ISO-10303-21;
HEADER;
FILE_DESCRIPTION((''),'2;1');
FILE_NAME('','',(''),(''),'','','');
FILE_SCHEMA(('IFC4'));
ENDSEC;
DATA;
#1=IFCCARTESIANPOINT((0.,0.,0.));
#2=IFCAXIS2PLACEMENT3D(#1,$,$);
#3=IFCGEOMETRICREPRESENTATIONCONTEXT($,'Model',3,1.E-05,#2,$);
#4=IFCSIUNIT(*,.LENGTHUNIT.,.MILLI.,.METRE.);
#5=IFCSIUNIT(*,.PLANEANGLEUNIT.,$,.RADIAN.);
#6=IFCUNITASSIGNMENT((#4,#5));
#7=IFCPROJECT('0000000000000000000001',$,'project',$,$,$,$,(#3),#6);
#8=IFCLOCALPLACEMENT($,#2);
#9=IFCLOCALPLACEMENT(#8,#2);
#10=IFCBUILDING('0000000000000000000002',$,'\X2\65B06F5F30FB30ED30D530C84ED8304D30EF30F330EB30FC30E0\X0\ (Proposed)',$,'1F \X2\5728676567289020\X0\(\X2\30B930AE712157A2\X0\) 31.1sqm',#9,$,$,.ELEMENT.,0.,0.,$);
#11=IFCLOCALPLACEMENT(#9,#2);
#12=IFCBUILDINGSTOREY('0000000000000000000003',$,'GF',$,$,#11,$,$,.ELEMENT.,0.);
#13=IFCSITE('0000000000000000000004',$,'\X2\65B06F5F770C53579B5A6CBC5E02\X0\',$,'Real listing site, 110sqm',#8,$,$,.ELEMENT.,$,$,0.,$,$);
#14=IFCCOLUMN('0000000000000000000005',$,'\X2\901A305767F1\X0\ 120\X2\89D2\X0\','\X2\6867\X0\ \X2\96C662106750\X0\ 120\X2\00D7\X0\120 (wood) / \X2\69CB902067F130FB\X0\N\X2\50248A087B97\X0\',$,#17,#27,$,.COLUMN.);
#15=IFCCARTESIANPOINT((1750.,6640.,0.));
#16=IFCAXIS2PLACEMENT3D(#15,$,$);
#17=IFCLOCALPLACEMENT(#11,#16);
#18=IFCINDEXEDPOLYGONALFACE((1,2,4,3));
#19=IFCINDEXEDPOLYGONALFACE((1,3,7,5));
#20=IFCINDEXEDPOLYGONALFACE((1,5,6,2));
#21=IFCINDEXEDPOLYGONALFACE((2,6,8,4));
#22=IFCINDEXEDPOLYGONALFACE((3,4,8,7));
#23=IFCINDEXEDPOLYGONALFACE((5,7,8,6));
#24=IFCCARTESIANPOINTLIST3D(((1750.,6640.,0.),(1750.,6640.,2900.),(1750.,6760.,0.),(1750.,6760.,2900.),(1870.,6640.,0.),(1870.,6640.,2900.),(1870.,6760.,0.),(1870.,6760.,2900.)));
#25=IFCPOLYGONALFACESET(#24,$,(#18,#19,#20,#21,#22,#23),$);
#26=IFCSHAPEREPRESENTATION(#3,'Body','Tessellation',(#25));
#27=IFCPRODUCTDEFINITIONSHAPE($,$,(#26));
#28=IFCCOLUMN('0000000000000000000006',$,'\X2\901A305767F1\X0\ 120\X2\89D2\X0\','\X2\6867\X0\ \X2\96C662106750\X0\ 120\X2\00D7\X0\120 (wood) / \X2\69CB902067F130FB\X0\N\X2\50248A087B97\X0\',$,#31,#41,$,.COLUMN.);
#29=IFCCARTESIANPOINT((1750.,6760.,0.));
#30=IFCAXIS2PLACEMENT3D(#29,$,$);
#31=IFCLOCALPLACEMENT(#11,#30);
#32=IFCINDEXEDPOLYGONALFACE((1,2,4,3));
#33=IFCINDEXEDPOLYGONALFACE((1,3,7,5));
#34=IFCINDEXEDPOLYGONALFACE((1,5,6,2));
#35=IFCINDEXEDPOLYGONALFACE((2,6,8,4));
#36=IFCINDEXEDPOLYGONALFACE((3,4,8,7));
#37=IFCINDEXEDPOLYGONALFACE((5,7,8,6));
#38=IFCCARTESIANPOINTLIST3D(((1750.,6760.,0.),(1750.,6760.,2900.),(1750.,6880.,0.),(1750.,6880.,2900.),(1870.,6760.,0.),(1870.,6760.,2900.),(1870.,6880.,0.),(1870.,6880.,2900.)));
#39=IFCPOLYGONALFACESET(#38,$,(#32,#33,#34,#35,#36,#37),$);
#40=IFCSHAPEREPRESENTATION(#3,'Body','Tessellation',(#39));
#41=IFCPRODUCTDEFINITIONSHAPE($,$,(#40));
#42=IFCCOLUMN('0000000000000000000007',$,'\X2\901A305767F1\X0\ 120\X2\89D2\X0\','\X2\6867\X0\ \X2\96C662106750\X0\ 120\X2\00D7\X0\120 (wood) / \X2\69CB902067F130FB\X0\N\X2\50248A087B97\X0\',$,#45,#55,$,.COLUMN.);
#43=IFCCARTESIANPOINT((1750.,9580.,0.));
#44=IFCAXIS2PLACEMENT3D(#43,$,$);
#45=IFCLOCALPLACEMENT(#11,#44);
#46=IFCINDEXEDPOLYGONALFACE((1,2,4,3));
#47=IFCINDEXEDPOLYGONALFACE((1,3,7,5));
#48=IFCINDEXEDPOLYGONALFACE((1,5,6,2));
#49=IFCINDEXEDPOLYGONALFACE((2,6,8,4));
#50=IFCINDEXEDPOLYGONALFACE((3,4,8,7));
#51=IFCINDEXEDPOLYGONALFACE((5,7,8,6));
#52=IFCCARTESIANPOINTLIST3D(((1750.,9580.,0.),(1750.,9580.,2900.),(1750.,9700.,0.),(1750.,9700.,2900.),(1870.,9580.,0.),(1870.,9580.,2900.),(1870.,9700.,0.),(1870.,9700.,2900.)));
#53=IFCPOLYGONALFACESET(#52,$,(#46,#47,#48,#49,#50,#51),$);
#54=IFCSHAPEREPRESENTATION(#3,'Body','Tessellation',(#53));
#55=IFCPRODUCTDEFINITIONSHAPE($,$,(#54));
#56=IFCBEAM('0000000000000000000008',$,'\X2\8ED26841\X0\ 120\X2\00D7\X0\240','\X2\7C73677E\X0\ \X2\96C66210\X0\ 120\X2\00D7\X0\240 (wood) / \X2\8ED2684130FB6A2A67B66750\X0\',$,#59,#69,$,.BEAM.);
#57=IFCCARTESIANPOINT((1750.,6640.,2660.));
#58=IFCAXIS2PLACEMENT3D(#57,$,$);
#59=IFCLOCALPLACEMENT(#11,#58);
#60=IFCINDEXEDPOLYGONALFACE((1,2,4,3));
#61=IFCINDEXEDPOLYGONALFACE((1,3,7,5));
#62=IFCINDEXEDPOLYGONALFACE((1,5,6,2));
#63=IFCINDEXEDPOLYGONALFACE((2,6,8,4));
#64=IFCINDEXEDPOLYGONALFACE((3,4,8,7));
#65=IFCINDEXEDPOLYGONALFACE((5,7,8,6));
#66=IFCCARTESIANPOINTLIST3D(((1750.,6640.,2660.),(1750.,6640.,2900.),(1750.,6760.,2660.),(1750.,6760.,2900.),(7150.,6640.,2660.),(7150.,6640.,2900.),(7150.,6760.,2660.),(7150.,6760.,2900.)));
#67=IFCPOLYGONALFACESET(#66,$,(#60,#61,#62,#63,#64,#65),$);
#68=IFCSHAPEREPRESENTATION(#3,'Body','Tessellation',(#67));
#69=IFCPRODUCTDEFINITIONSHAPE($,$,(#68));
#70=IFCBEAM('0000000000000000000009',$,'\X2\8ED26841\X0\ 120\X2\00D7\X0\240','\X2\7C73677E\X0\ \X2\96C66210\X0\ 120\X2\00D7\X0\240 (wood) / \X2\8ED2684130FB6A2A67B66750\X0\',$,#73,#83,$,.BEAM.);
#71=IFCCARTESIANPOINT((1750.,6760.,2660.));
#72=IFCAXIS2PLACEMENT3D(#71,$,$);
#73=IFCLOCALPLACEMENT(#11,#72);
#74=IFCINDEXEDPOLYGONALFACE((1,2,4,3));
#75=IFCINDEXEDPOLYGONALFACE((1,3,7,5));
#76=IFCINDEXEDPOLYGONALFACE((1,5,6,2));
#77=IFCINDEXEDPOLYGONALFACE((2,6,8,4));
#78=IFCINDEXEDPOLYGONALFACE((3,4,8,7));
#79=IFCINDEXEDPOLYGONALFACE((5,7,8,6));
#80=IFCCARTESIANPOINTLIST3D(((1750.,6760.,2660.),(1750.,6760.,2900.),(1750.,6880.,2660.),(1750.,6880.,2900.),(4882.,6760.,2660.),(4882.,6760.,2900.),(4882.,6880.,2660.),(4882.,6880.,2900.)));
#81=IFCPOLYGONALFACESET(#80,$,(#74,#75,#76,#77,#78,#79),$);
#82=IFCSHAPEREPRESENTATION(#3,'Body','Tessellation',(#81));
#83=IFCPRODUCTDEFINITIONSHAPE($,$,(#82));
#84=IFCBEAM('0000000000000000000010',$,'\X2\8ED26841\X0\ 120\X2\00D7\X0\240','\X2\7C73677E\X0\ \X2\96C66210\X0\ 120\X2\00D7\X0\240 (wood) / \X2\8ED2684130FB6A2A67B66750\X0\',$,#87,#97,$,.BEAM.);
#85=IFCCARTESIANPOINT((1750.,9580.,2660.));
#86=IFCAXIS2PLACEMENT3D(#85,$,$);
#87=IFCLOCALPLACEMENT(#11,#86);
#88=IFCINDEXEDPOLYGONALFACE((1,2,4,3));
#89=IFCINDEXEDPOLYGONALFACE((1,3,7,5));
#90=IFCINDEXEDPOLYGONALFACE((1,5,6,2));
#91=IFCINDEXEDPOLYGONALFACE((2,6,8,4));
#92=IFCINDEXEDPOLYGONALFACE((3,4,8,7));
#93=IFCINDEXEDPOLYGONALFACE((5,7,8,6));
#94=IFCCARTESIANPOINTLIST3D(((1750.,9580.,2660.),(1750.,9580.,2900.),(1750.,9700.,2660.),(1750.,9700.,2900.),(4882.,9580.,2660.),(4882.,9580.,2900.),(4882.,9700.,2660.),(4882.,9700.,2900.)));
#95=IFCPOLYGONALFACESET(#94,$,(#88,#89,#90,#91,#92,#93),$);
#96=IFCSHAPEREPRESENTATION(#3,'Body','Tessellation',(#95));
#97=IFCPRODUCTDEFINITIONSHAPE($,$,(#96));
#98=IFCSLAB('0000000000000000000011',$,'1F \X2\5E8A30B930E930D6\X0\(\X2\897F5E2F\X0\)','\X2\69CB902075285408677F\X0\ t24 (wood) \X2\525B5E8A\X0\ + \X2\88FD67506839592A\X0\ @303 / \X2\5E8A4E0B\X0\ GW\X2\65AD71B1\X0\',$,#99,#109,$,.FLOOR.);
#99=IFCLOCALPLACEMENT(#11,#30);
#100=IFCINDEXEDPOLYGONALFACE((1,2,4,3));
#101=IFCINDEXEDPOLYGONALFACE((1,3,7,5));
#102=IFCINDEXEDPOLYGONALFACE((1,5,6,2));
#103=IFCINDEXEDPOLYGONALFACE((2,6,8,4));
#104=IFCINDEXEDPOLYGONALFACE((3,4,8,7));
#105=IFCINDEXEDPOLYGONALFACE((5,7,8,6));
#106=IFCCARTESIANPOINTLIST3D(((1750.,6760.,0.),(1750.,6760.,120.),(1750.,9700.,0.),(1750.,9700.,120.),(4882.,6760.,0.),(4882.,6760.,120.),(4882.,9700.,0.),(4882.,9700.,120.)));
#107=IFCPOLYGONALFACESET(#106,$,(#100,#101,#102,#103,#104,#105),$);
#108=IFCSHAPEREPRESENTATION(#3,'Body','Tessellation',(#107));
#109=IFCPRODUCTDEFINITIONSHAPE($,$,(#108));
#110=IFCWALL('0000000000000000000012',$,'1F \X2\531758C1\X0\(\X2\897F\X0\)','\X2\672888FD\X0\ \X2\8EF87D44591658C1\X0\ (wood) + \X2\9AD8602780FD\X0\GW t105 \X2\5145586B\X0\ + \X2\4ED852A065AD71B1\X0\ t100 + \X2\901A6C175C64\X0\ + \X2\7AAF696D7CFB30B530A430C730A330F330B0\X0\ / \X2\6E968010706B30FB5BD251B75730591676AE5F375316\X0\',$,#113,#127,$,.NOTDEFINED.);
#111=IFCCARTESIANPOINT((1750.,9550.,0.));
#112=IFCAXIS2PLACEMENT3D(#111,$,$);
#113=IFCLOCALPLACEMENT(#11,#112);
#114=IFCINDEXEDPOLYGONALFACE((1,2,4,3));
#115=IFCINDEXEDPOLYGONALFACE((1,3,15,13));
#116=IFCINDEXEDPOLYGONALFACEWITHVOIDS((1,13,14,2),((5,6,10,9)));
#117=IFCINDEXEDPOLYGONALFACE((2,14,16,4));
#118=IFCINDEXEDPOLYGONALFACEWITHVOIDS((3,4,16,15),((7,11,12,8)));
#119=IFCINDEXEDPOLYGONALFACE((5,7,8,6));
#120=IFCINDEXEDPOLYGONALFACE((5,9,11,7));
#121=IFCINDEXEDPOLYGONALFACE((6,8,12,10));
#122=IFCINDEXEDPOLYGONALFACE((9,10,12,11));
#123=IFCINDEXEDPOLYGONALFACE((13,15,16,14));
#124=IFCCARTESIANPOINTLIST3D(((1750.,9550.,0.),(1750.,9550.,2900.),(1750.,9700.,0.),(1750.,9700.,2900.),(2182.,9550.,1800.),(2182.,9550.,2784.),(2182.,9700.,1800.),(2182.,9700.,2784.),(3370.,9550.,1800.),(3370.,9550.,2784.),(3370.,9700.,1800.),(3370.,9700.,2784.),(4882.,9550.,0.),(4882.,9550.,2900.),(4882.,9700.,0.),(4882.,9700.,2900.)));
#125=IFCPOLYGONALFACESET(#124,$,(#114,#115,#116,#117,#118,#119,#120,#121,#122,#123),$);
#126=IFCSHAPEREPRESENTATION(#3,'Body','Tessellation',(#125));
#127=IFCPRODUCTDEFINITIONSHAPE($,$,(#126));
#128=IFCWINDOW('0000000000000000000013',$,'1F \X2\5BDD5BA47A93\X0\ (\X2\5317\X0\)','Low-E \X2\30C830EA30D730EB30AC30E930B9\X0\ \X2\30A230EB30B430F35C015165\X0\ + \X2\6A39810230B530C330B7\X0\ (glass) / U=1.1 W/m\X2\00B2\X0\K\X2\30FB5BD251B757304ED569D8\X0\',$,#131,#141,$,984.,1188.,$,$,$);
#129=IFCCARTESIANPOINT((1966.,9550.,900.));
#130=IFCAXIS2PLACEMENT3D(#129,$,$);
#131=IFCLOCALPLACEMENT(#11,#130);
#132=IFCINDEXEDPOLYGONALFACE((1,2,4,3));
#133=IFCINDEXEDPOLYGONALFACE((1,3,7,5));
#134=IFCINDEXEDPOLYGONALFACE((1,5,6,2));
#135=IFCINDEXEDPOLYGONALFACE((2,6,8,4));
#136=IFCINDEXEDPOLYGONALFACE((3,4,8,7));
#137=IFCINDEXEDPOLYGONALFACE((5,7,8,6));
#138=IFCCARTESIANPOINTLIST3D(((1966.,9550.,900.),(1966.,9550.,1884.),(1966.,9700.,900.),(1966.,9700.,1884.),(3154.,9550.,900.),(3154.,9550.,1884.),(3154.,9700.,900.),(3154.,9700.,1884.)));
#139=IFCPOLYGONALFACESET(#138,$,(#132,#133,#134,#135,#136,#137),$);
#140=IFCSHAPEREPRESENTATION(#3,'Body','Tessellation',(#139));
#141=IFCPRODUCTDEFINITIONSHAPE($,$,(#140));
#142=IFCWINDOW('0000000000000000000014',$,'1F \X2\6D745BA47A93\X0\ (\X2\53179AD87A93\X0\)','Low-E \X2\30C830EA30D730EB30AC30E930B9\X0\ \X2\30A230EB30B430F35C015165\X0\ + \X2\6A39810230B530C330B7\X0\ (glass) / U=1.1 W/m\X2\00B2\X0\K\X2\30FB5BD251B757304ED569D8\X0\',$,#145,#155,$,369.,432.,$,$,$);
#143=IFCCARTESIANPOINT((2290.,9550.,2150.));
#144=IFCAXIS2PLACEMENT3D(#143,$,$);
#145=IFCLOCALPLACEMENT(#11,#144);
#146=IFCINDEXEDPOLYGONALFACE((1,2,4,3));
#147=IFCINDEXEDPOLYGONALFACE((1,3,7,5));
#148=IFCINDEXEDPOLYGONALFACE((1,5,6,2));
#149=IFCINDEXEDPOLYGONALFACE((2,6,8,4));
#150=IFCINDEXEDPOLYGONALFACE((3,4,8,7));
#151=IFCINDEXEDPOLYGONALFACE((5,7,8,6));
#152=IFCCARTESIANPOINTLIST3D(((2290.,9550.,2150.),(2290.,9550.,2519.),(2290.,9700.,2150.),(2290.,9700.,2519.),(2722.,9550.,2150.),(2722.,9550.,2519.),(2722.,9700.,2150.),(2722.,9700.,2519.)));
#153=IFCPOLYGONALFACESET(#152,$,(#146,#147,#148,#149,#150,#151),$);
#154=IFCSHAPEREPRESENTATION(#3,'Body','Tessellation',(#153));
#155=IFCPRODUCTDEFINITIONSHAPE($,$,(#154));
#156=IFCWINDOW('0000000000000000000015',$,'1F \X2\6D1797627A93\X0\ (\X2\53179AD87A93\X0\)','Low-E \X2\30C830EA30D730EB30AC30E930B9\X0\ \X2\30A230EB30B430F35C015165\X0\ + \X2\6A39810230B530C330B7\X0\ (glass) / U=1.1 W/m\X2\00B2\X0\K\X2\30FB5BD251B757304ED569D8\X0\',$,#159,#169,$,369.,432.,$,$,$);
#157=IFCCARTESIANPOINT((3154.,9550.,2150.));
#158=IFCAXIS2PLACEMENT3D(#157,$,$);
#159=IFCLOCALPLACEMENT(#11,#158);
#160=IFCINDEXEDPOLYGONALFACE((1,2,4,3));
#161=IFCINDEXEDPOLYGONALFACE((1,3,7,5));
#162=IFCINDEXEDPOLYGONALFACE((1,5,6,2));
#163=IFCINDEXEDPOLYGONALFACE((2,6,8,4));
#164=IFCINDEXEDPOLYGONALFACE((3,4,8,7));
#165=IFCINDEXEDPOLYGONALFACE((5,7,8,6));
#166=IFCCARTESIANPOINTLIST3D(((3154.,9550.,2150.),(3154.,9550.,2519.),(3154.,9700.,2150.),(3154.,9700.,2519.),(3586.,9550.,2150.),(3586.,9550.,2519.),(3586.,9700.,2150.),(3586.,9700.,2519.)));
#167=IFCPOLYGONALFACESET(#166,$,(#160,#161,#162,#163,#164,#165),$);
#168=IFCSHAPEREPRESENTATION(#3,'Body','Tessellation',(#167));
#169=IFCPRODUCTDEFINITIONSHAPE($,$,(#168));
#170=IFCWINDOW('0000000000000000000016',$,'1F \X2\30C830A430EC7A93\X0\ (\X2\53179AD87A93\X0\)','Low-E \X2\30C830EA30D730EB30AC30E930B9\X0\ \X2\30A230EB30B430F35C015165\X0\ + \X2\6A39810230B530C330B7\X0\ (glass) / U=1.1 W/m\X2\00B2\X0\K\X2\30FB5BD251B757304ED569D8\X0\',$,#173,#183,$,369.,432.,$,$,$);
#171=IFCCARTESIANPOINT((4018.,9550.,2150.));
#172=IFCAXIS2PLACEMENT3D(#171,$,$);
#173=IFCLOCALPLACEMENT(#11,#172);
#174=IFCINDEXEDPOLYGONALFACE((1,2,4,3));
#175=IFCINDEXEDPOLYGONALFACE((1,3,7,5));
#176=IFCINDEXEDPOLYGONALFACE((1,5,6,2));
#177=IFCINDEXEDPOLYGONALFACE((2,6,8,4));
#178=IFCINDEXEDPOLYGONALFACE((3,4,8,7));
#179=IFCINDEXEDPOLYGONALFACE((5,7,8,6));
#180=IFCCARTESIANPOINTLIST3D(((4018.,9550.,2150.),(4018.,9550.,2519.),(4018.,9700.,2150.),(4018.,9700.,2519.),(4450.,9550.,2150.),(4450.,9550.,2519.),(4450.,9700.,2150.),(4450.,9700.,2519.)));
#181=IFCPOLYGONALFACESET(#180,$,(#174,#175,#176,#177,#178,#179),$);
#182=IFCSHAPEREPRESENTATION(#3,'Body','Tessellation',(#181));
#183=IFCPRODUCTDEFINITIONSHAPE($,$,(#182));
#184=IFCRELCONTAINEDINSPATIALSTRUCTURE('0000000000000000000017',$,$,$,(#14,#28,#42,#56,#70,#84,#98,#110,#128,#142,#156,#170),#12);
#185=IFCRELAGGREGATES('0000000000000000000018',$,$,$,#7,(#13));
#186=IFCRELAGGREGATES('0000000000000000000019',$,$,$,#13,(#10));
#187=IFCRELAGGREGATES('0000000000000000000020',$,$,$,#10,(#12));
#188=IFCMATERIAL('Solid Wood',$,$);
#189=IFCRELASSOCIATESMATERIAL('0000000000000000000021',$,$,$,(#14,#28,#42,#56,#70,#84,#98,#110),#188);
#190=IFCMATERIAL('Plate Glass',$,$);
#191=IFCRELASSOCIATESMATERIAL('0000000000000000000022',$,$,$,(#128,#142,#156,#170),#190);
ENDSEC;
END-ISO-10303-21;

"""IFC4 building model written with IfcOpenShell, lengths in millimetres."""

from ifc_helpers import new_model, si_unit, frame, frame_2d, origin, place, context, project, spatial, rectangle, extrude, material, element, fill, save


model = new_model("IFC4")

# Units and contexts
model_context = context("Model", 3, precision=1e-05, world=origin())
ifc_project = project(units=[si_unit("LENGTHUNIT", "METRE", prefix="MILLI"), si_unit("PLANEANGLEUNIT", "RADIAN")], contexts=[model_context])

# Site, building, storey
site_placement = place(None, origin())
site = spatial("IfcSite", under=ifc_project, at=site_placement, Name="新潟県南魚沼市", ObjectType="Real listing site, 110sqm", CompositionType="ELEMENT", RefElevation=0.0)
building_placement = place(site_placement, origin())
building = spatial("IfcBuilding", under=site, at=building_placement, Name="新潟・ロフト付きワンルーム (Proposed)", ObjectType="1F 在来木造(スギ無垢) 31.1sqm", CompositionType="ELEMENT", ElevationOfRefHeight=0.0, ElevationOfTerrain=0.0)
storey_placement = place(building_placement, origin())
storey = spatial("IfcBuildingStorey", under=building, at=storey_placement, Name="GF", CompositionType="ELEMENT", Elevation=0.0)

# Columns
ifc_material_1 = material(Name="Solid Wood")
column_1_placement = place(storey_placement, frame((1750.0, 6640.0, 0.0)))
element("IfcColumn", 1, at=column_1_placement, inside=storey, material=ifc_material_1, Name="通し柱 120角", Description="桧 集成材 120×120 (wood) / 構造柱・N値計算", PredefinedType="COLUMN", context=model_context, shape_type="SweptSolid", body=[
    extrude(rectangle(XDim=120.0, YDim=120.0, at=frame_2d((60.0, 60.0))), frame((1750.0, 6640.0, 0.0)), (0.0, 0.0, 1.0), 2900.0),
])
column_2_placement = place(storey_placement, frame((1750.0, 6760.0, 0.0)))
element("IfcColumn", 2, at=column_2_placement, inside=storey, material=ifc_material_1, Name="通し柱 120角", Description="桧 集成材 120×120 (wood) / 構造柱・N値計算", PredefinedType="COLUMN", context=model_context, shape_type="SweptSolid", body=[
    extrude(rectangle(XDim=120.0, YDim=120.0, at=frame_2d((60.0, 60.0))), frame((1750.0, 6760.0, 0.0)), (0.0, 0.0, 1.0), 2900.0),
])
column_3_placement = place(storey_placement, frame((1750.0, 9580.0, 0.0)))
element("IfcColumn", 3, at=column_3_placement, inside=storey, material=ifc_material_1, Name="通し柱 120角", Description="桧 集成材 120×120 (wood) / 構造柱・N値計算", PredefinedType="COLUMN", context=model_context, shape_type="SweptSolid", body=[
    extrude(rectangle(XDim=120.0, YDim=120.0, at=frame_2d((60.0, 60.0))), frame((1750.0, 9580.0, 0.0)), (0.0, 0.0, 1.0), 2900.0),
])

# Beams
beam_1_placement = place(storey_placement, frame((1750.0, 6640.0, 2660.0)))
element("IfcBeam", 4, at=beam_1_placement, inside=storey, material=ifc_material_1, Name="軒桁 120×240", Description="米松 集成 120×240 (wood) / 軒桁・横架材", PredefinedType="BEAM", context=model_context, shape_type="SweptSolid", body=[
    extrude(rectangle(XDim=5400.0, YDim=120.0, at=frame_2d((2700.0, 60.0))), frame((1750.0, 6640.0, 2660.0)), (0.0, 0.0, 1.0), 240.0),
])
beam_2_placement = place(storey_placement, frame((1750.0, 6760.0, 2660.0)))
element("IfcBeam", 5, at=beam_2_placement, inside=storey, material=ifc_material_1, Name="軒桁 120×240", Description="米松 集成 120×240 (wood) / 軒桁・横架材", PredefinedType="BEAM", context=model_context, shape_type="SweptSolid", body=[
    extrude(rectangle(XDim=3132.0, YDim=120.0, at=frame_2d((1566.0, 60.0))), frame((1750.0, 6760.0, 2660.0)), (0.0, 0.0, 1.0), 240.0),
])
beam_3_placement = place(storey_placement, frame((1750.0, 9580.0, 2660.0)))
element("IfcBeam", 6, at=beam_3_placement, inside=storey, material=ifc_material_1, Name="軒桁 120×240", Description="米松 集成 120×240 (wood) / 軒桁・横架材", PredefinedType="BEAM", context=model_context, shape_type="SweptSolid", body=[
    extrude(rectangle(XDim=3132.0, YDim=120.0, at=frame_2d((1566.0, 60.0))), frame((1750.0, 9580.0, 2660.0)), (0.0, 0.0, 1.0), 240.0),
])

# Slab
slab_placement = place(storey_placement, frame((1750.0, 6760.0, 0.0)))
element("IfcSlab", 7, at=slab_placement, inside=storey, material=ifc_material_1, Name="1F 床スラブ(西帯)", Description="構造用合板 t24 (wood) 剛床 + 製材根太 @303 / 床下 GW断熱", PredefinedType="FLOOR", context=model_context, shape_type="SweptSolid", body=[
    extrude(rectangle(XDim=3132.0, YDim=2940.0, at=frame_2d((1566.0, 1470.0))), frame((1750.0, 6760.0, 0.0)), (0.0, 0.0, 1.0), 120.0),
])

# Wall, openings, windows
wall_1_placement = place(storey_placement, frame((1750.0, 9550.0, 0.0)))
wall_1 = element("IfcWall", 8, at=wall_1_placement, inside=storey, material=ifc_material_1, Name="1F 北壁(西)", Description="木製 軸組外壁 (wood) + 高性能GW t105 充填 + 付加断熱 t100 + 通気層 + 窯業系サイディング / 準耐火・寒冷地外皮強化", PredefinedType="NOTDEFINED", context=model_context, shape_type="SweptSolid", body=[
    extrude(rectangle(XDim=3132.0, YDim=150.0, at=frame_2d((1566.0, 75.0))), frame((1750.0, 9550.0, 0.0)), (0.0, 0.0, 1.0), 2900.0),
])
opening_1_placement = place(storey_placement, frame((1966.0, 9550.0, 900.0)))
opening_1 = element("IfcOpeningElement", 9, at=opening_1_placement, cuts=wall_1, PredefinedType="NOTDEFINED", context=model_context, shape_type="SweptSolid", body=[
    extrude(rectangle(XDim=1188.0, YDim=150.0, at=frame_2d((594.0, 75.0))), frame((1966.0, 9550.0, 900.0)), (0.0, 0.0, 1.0), 984.0),
])
opening_2_placement = place(storey_placement, frame((2290.0, 9550.0, 2150.0)))
opening_2 = element("IfcOpeningElement", 10, at=opening_2_placement, cuts=wall_1, PredefinedType="NOTDEFINED", context=model_context, shape_type="SweptSolid", body=[
    extrude(rectangle(XDim=432.0, YDim=150.0, at=frame_2d((216.0, 75.0))), frame((2290.0, 9550.0, 2150.0)), (0.0, 0.0, 1.0), 369.0),
])
opening_3_placement = place(storey_placement, frame((3154.0, 9550.0, 2150.0)))
opening_3 = element("IfcOpeningElement", 11, at=opening_3_placement, cuts=wall_1, PredefinedType="NOTDEFINED", context=model_context, shape_type="SweptSolid", body=[
    extrude(rectangle(XDim=432.0, YDim=150.0, at=frame_2d((216.0, 75.0))), frame((3154.0, 9550.0, 2150.0)), (0.0, 0.0, 1.0), 369.0),
])
opening_4_placement = place(storey_placement, frame((4018.0, 9550.0, 2150.0)))
opening_4 = element("IfcOpeningElement", 12, at=opening_4_placement, cuts=wall_1, PredefinedType="NOTDEFINED", context=model_context, shape_type="SweptSolid", body=[
    extrude(rectangle(XDim=432.0, YDim=150.0, at=frame_2d((216.0, 75.0))), frame((4018.0, 9550.0, 2150.0)), (0.0, 0.0, 1.0), 369.0),
])
ifc_material_2 = material(Name="Plate Glass")
window_1_placement = place(storey_placement, frame((1966.0, 9550.0, 900.0)))
window_1 = element("IfcWindow", 13, at=window_1_placement, inside=storey, material=ifc_material_2, Name="1F 寝室窓 (北)", Description="Low-E トリプルガラス アルゴン封入 + 樹脂サッシ (glass) / U=1.1 W/m²K・寒冷地仕様", OverallHeight=984.0, OverallWidth=1188.0, context=model_context, shape_type="SweptSolid", body=[
    extrude(rectangle(XDim=1188.0, YDim=150.0, at=frame_2d((594.0, 75.0))), frame((1966.0, 9550.0, 900.0)), (0.0, 0.0, 1.0), 984.0),
])
fill(opening_1, window_1)
window_2_placement = place(storey_placement, frame((2290.0, 9550.0, 2150.0)))
window_2 = element("IfcWindow", 14, at=window_2_placement, inside=storey, material=ifc_material_2, Name="1F 浴室窓 (北高窓)", Description="Low-E トリプルガラス アルゴン封入 + 樹脂サッシ (glass) / U=1.1 W/m²K・寒冷地仕様", OverallHeight=369.0, OverallWidth=432.0, context=model_context, shape_type="SweptSolid", body=[
    extrude(rectangle(XDim=432.0, YDim=150.0, at=frame_2d((216.0, 75.0))), frame((2290.0, 9550.0, 2150.0)), (0.0, 0.0, 1.0), 369.0),
])
fill(opening_2, window_2)
window_3_placement = place(storey_placement, frame((3154.0, 9550.0, 2150.0)))
window_3 = element("IfcWindow", 15, at=window_3_placement, inside=storey, material=ifc_material_2, Name="1F 洗面窓 (北高窓)", Description="Low-E トリプルガラス アルゴン封入 + 樹脂サッシ (glass) / U=1.1 W/m²K・寒冷地仕様", OverallHeight=369.0, OverallWidth=432.0, context=model_context, shape_type="SweptSolid", body=[
    extrude(rectangle(XDim=432.0, YDim=150.0, at=frame_2d((216.0, 75.0))), frame((3154.0, 9550.0, 2150.0)), (0.0, 0.0, 1.0), 369.0),
])
fill(opening_3, window_3)
window_4_placement = place(storey_placement, frame((4018.0, 9550.0, 2150.0)))
window_4 = element("IfcWindow", 16, at=window_4_placement, inside=storey, material=ifc_material_2, Name="1F トイレ窓 (北高窓)", Description="Low-E トリプルガラス アルゴン封入 + 樹脂サッシ (glass) / U=1.1 W/m²K・寒冷地仕様", OverallHeight=369.0, OverallWidth=432.0, context=model_context, shape_type="SweptSolid", body=[
    extrude(rectangle(XDim=432.0, YDim=150.0, at=frame_2d((216.0, 75.0))), frame((4018.0, 9550.0, 2150.0)), (0.0, 0.0, 1.0), 369.0),
])
fill(opening_4, window_4)

save(model, "model.ifc")
